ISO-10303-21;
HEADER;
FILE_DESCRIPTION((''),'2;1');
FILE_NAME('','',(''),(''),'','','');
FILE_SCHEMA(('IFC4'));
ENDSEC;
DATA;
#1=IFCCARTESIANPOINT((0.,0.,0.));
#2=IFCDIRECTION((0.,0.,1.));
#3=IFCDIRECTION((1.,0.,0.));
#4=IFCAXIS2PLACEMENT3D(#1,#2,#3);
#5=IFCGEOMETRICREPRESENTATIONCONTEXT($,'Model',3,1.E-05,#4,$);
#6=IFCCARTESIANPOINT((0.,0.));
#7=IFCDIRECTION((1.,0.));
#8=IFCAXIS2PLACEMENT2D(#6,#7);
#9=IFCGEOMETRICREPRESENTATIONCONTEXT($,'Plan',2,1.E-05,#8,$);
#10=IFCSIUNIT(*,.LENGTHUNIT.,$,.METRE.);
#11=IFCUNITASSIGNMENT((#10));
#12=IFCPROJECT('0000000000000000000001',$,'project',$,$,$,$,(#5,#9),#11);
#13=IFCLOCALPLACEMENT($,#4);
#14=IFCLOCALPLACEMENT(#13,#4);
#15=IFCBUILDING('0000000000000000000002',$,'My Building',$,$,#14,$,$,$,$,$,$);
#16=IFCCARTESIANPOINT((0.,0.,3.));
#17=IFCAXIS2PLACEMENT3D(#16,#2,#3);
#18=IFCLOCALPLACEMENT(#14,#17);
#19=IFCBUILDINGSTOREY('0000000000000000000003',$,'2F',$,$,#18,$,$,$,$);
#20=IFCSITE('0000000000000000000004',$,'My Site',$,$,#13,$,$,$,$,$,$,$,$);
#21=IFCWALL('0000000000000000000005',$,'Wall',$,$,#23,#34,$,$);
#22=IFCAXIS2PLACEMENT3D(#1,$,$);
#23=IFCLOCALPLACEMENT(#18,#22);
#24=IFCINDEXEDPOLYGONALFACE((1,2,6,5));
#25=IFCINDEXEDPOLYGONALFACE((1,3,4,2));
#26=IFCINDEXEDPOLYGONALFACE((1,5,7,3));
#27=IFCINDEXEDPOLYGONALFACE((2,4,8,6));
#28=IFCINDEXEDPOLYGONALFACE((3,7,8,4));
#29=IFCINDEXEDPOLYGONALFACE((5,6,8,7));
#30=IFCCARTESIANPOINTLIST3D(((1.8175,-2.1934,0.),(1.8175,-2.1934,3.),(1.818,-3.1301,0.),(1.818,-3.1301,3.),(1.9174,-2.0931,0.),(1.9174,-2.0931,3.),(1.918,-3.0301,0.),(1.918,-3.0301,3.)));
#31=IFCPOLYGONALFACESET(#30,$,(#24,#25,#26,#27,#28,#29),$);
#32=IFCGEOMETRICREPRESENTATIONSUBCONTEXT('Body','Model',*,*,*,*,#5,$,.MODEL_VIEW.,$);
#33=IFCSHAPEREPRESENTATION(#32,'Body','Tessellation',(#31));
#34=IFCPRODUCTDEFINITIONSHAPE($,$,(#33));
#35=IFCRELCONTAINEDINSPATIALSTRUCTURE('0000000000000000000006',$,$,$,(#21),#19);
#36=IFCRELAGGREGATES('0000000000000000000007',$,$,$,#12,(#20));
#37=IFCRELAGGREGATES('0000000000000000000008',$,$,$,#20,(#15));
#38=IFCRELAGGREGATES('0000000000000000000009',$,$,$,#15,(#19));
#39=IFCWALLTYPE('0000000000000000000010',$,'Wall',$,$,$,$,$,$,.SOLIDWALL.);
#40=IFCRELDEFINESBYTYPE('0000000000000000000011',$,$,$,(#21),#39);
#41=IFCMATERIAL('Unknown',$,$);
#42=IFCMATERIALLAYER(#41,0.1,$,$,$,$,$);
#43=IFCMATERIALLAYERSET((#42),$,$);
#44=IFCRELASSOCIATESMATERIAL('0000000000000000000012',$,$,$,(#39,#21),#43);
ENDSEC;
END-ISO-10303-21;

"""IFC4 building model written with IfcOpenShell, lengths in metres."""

from ifc_helpers import new_model, si_unit, frame, origin_with_axes, origin_2d_with_axis, place, context, subcontext, project, spatial, line, indexed_curve, outline, extrude, material, layer, layer_set, layer_usage, type_object, element, save


model = new_model("IFC4")

# Units and contexts
model_context = context("Model", 3, precision=1e-05, world=origin_with_axes())
plan_context = context("Plan", 2, precision=1e-05, world=origin_2d_with_axis())
body_context_1 = subcontext(model_context, "Body", "Model", "MODEL_VIEW")
ifc_project = project(units=[si_unit("LENGTHUNIT", "METRE")], contexts=[model_context, plan_context])

# Site, building, storey
site_placement = place(None, origin_with_axes())
site = spatial("IfcSite", under=ifc_project, at=site_placement, Name="My Site")
building_placement = place(site_placement, origin_with_axes())
building = spatial("IfcBuilding", under=site, at=building_placement, Name="My Building")
storey_placement = place(building_placement, frame((0.0, 0.0, 3.0), z_axis=(0.0, 0.0, 1.0), x_axis=(1.0, 0.0, 0.0)))
storey = spatial("IfcBuildingStorey", under=building, at=storey_placement, Name="2F")

# Shared definitions
ifc_material = material(Name="Unknown")

# Shared definitions
ifc_layer = layer(ifc_material, 0.1)
ifc_layer_set = layer_set([ifc_layer])
wall_type = type_object("IfcWallType", Name="Wall", PredefinedType="SOLIDWALL", material=ifc_layer_set)

# Wall
ifc_layer_usage_1 = layer_usage(ifc_layer_set, "AXIS2", "POSITIVE", 0.0)
wall_1_placement = place(storey_placement, frame((1.8175, -2.1934, 0.0), z_axis=(0.0, 0.0, 1.0), x_axis=(0.000608, -1.0, 0.0)))
element("IfcWall", 1, at=wall_1_placement, inside=storey, type_object=wall_type, material=ifc_layer_usage_1, Name="Wall", context=body_context_1, shape_type="SweptSolid", body=[
    extrude(outline(indexed_curve([(0.0, 0.0), (-0.1002, 0.1), (0.8368, 0.1), (0.9368, 0.0)], segments=[line(1, 2, 3, 4, 1)])), origin_with_axes(), (0.0, 0.0, 1.0), 3.0),
])

save(model, "model.ifc")
